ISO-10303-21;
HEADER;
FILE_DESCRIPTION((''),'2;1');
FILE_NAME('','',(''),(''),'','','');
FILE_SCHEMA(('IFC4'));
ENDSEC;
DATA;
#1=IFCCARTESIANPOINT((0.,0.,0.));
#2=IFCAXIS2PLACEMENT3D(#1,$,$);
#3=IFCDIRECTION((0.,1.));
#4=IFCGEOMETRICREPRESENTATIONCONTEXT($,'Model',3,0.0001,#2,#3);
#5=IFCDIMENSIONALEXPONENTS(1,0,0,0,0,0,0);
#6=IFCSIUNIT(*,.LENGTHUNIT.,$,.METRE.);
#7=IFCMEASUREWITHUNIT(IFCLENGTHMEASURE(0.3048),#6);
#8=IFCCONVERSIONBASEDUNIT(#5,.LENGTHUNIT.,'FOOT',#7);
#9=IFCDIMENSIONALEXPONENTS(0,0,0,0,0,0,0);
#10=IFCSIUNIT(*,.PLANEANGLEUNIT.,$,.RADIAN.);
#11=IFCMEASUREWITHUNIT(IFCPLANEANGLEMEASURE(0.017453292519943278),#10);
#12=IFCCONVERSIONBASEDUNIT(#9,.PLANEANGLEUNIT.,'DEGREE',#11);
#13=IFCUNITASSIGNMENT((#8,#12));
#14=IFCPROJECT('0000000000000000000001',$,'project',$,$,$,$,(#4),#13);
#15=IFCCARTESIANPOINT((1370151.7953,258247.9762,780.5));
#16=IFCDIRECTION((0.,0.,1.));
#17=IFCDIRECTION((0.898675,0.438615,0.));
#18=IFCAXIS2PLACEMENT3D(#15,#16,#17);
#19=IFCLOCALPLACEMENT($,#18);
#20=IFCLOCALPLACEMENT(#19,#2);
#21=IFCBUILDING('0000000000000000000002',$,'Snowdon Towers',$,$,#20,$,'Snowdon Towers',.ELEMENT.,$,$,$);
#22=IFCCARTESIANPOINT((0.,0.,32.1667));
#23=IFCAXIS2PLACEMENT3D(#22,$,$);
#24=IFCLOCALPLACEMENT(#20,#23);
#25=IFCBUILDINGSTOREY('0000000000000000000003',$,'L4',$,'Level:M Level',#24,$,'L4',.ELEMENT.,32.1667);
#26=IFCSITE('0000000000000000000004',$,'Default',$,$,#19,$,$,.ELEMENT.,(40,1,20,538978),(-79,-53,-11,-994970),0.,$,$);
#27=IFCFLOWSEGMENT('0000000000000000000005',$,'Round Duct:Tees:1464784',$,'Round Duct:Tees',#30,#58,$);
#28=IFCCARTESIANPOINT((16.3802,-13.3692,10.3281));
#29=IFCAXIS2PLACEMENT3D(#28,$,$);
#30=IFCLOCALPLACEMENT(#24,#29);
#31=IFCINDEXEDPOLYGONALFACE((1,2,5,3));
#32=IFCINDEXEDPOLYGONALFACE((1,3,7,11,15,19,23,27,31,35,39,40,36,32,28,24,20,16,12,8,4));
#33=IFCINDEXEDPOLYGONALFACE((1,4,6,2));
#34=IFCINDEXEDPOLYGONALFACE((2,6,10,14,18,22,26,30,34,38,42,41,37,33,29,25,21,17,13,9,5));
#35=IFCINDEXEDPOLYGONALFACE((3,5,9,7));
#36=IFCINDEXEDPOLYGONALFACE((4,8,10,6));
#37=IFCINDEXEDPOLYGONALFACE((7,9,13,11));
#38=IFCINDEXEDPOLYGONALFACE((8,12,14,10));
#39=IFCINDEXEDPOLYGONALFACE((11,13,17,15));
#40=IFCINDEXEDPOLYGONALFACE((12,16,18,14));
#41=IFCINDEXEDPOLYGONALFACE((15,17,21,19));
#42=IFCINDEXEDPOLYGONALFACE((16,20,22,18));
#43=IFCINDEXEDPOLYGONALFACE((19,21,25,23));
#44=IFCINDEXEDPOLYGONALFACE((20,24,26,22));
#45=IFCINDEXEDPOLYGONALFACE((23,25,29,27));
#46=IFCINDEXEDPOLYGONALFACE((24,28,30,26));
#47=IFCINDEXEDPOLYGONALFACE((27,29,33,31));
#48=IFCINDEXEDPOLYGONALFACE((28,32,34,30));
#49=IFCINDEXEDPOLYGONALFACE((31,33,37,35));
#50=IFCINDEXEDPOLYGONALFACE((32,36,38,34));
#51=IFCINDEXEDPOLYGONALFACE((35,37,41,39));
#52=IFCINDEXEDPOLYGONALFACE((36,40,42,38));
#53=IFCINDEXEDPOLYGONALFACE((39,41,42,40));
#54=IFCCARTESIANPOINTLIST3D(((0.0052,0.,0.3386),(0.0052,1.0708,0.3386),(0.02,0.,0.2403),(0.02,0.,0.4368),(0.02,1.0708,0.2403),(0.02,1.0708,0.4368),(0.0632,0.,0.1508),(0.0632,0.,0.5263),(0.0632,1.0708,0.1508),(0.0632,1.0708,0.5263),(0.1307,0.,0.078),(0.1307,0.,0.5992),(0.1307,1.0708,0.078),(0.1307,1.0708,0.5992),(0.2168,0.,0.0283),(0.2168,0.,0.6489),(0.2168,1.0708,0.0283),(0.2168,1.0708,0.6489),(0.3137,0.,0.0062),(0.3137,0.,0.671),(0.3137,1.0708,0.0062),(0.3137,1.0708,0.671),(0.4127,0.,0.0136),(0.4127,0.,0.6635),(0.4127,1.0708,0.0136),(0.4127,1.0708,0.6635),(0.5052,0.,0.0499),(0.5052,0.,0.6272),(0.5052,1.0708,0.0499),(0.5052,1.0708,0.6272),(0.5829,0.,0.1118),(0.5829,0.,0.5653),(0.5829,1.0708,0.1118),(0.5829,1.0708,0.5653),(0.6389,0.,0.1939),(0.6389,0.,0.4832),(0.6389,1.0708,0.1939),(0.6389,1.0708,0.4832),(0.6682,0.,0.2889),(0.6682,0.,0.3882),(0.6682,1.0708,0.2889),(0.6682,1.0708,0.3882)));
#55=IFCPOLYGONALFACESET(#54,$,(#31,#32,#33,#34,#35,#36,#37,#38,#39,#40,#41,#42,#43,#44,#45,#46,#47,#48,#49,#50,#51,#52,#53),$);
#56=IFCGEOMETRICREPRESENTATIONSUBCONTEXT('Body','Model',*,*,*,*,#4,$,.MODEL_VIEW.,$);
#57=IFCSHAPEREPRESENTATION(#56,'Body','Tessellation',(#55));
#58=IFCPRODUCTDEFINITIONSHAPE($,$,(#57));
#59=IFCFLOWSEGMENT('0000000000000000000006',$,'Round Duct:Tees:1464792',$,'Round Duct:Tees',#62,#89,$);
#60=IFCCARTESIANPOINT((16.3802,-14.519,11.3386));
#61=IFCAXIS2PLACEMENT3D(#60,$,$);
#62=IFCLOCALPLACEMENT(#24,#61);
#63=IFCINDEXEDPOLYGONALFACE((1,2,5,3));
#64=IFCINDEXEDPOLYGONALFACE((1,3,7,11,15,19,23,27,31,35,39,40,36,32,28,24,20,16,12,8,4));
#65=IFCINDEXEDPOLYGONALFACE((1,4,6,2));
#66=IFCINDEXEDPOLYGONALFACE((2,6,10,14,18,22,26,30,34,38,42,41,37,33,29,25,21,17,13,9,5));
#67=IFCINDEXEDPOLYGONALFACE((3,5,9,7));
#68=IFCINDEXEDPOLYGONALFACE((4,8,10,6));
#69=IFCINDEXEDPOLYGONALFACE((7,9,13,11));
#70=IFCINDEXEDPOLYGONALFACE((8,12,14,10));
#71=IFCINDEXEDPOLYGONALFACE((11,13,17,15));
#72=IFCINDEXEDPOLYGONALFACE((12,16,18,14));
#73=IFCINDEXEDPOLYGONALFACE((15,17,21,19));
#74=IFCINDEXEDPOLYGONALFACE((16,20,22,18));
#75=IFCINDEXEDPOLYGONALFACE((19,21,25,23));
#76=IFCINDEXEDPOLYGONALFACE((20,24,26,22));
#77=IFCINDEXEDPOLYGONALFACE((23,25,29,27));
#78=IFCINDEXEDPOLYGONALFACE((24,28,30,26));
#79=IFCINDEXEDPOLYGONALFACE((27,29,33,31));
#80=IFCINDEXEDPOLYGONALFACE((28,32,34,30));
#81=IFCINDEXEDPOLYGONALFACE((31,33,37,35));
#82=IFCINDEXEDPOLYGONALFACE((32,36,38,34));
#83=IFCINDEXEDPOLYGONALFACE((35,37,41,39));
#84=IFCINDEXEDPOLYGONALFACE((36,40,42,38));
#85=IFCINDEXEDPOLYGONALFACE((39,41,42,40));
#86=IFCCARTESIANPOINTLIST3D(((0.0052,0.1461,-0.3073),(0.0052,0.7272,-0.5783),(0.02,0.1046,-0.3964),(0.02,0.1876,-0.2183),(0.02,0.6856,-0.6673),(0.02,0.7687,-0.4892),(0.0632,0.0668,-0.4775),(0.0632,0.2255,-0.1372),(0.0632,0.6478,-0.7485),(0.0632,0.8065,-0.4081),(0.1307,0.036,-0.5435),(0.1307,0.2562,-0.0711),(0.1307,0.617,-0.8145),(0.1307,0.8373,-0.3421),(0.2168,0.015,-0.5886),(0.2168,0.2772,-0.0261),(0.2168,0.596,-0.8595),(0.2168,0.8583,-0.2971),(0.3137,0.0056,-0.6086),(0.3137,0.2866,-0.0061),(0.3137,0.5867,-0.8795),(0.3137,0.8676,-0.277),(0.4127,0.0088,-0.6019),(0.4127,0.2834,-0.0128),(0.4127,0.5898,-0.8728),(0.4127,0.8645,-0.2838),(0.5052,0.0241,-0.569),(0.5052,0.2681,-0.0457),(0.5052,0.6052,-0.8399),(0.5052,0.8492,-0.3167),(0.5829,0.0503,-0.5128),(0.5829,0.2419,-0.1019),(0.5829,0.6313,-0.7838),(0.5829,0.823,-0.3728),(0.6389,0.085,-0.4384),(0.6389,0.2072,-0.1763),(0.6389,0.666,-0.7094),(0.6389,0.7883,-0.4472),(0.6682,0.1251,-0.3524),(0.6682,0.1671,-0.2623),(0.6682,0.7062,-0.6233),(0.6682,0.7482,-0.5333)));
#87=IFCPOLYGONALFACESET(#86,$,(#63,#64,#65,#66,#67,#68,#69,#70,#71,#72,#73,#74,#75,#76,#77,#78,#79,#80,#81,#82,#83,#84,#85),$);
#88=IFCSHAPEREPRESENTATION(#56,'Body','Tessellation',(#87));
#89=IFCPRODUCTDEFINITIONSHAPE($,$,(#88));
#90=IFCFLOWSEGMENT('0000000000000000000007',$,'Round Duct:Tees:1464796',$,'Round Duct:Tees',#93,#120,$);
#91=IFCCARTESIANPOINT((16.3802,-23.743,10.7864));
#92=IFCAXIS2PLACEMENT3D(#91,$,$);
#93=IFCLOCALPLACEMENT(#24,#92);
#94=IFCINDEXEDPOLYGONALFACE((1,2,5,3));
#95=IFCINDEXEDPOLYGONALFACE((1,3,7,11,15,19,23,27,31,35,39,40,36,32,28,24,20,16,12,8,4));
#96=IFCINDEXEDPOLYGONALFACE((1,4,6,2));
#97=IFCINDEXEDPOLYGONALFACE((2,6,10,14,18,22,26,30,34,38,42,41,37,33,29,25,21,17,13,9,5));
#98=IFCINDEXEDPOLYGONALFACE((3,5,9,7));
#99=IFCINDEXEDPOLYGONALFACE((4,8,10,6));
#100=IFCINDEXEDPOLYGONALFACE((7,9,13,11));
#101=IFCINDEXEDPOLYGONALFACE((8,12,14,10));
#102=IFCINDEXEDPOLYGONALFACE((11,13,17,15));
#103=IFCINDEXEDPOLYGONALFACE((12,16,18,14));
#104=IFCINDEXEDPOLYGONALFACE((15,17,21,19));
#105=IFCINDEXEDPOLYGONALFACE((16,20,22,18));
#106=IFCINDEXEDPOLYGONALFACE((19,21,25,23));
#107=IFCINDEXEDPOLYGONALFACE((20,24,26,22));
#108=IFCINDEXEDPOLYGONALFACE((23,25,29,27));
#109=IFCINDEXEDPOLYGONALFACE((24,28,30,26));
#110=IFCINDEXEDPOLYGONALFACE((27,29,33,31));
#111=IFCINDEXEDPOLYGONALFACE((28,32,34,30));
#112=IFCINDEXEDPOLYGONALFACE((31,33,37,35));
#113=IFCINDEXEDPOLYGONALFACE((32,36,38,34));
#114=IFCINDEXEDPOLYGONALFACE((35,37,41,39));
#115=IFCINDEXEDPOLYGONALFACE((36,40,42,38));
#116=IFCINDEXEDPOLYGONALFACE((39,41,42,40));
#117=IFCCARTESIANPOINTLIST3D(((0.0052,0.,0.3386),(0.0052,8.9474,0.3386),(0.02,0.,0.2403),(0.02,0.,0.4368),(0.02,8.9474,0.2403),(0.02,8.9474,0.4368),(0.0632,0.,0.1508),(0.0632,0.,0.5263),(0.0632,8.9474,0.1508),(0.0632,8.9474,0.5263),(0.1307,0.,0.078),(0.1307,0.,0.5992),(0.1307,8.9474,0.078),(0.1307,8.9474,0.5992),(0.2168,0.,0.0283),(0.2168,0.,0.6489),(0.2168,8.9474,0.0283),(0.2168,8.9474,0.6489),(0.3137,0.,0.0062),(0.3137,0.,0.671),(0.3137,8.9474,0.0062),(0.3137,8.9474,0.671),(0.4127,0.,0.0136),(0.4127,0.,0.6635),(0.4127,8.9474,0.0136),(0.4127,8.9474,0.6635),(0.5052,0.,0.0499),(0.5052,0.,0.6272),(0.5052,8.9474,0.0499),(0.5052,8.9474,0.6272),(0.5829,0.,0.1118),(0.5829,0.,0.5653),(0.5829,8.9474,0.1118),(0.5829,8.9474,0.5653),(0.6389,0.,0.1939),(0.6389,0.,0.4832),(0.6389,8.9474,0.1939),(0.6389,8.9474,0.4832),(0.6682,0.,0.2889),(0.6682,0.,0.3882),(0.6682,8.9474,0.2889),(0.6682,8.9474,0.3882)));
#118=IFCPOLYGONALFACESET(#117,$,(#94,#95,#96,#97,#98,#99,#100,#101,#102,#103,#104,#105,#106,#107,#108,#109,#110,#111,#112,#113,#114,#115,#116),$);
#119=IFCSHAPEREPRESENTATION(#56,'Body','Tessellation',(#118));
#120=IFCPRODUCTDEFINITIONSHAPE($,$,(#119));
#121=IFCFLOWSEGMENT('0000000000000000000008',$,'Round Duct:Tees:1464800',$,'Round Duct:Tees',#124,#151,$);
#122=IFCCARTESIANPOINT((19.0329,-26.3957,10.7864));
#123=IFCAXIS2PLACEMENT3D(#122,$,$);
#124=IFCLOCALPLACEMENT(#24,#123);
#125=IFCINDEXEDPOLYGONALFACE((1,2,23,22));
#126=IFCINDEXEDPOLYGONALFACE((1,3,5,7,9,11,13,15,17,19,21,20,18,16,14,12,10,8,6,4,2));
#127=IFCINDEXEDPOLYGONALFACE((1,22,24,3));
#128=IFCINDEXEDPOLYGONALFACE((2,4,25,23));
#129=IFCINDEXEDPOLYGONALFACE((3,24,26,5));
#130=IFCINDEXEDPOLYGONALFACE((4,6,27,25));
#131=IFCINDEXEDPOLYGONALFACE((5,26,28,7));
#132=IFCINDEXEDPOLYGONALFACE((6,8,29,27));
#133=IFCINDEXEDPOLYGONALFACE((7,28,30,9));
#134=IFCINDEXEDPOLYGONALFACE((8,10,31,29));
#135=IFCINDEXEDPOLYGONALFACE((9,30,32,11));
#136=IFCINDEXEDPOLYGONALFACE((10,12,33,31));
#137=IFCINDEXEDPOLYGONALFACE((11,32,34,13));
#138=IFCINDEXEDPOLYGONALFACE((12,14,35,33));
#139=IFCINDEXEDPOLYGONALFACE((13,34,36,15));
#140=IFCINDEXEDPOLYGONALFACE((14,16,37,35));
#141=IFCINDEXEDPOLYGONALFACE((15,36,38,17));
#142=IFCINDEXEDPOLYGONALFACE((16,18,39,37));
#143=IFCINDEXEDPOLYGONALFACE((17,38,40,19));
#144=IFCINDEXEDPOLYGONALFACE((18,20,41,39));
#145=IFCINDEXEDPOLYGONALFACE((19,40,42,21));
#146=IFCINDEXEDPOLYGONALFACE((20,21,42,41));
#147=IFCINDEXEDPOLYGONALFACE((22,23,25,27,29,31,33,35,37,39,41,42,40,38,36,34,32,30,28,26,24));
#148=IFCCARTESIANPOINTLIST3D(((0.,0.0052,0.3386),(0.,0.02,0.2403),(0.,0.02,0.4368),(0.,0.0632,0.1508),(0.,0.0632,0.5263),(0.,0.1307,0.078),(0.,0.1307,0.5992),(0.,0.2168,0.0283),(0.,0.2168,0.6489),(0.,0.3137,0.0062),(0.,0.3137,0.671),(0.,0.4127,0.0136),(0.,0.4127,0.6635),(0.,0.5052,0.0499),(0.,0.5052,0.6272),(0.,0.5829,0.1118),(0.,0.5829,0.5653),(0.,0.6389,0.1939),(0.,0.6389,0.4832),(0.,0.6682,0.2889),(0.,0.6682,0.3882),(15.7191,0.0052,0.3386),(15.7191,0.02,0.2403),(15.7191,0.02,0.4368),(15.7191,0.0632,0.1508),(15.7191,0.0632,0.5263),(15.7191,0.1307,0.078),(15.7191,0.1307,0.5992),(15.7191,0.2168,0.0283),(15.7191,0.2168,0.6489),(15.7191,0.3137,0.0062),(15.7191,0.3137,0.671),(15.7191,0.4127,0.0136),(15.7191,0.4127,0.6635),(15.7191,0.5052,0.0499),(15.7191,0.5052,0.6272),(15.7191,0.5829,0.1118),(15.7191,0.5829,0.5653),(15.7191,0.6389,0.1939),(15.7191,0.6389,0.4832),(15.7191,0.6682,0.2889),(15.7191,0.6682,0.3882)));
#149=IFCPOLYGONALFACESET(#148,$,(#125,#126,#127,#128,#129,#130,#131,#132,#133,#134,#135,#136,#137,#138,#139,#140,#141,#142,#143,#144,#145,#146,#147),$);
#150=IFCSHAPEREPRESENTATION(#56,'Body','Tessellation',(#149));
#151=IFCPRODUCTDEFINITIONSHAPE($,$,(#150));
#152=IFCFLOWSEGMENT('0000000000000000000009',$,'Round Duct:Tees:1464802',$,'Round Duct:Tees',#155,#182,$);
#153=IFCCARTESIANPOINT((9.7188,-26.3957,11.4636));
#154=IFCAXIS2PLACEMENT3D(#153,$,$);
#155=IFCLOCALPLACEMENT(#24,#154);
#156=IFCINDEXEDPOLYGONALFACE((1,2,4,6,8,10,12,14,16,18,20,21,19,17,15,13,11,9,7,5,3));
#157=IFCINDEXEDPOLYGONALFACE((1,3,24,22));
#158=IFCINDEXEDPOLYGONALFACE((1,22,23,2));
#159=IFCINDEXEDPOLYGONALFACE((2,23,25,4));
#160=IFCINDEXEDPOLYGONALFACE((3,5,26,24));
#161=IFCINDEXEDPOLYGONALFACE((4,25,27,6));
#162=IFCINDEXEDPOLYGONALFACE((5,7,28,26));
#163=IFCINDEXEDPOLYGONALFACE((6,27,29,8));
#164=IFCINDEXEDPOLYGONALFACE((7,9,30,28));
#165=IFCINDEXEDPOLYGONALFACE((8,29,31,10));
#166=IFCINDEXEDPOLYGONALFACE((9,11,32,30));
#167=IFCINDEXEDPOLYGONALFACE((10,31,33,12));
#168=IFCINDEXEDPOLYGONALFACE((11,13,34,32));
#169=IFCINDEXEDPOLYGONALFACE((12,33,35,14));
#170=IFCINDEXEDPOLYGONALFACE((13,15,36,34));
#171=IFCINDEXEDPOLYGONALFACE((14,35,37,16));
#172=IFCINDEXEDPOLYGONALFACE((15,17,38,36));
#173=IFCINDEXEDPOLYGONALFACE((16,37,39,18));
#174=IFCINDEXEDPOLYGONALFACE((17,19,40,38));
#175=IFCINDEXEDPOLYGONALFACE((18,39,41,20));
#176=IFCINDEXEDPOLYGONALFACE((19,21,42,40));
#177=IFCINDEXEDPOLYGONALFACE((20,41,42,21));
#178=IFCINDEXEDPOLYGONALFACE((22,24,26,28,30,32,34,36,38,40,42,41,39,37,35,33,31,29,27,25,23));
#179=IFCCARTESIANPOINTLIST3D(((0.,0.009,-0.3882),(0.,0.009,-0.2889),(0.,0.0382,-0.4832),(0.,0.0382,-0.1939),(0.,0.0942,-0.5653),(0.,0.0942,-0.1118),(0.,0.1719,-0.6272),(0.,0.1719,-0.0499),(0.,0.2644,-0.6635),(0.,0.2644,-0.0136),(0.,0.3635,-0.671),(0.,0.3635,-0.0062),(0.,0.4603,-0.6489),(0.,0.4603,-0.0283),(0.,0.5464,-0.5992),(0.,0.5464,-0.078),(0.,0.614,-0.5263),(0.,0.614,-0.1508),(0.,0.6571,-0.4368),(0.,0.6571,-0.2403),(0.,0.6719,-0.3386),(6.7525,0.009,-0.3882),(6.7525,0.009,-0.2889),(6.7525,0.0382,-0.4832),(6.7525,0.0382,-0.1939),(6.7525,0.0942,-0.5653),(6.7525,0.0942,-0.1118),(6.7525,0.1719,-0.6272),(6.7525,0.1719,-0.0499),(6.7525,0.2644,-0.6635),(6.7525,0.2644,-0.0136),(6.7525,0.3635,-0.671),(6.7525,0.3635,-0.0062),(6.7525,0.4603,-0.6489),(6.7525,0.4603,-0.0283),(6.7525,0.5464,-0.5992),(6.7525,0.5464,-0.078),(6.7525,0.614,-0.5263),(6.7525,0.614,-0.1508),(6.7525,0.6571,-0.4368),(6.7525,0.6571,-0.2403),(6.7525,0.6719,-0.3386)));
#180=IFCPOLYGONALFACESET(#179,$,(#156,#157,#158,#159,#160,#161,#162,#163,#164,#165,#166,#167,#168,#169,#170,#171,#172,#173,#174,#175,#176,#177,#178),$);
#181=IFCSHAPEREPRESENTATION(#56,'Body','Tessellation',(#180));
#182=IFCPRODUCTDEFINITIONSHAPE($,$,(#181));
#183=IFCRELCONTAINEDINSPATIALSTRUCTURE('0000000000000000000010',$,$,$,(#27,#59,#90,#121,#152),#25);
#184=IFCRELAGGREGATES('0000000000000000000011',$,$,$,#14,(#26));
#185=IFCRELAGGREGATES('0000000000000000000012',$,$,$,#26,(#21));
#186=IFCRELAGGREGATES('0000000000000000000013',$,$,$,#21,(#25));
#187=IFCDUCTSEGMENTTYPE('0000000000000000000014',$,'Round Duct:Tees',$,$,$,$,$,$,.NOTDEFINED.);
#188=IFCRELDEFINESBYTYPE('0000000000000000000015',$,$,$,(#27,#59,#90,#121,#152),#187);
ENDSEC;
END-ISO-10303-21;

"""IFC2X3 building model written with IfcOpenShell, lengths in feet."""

from ifc_helpers import new_model, entity, si_unit, converted_unit, direction, frame, frame_2d, origin, origin_2d_with_axis, place, context, subcontext, project, spatial, circle, extrude, type_object, element, save


model = new_model("IFC2X3")

# Units and contexts
model_context = context("Model", 3, precision=0.0001, world=origin(), true_north=direction((0.0, 1.0)))
body_context = subcontext(model_context, "Body", "Model", "MODEL_VIEW")
ifc_project = project(units=[converted_unit("LENGTHUNIT", "FOOT", entity("IfcLengthMeasure", 0.3048), si_unit("LENGTHUNIT", "METRE"), dimensions=[1, 0, 0, 0, 0, 0, 0]), converted_unit("PLANEANGLEUNIT", "DEGREE", entity("IfcPlaneAngleMeasure", 0.017453292519943278), si_unit("PLANEANGLEUNIT", "RADIAN"), dimensions=[0, 0, 0, 0, 0, 0, 0])], contexts=[model_context])

# Site, building, storey
site_placement = place(None, frame((1370151.7953, 258247.9762, 780.5), z_axis=(0.0, 0.0, 1.0), x_axis=(0.898675, 0.438615, 0.0)))
site = spatial("IfcSite", under=ifc_project, at=site_placement, Name="Default", CompositionType="ELEMENT", RefLatitude=(40, 1, 20, 538978), RefLongitude=(-79, -53, -11, -994970), RefElevation=0.0)
building_placement = place(site_placement, origin())
building = spatial("IfcBuilding", under=site, at=building_placement, Name="Snowdon Towers", LongName="Snowdon Towers", CompositionType="ELEMENT")
storey_placement = place(building_placement, frame((0.0, 0.0, 32.1667)))
storey = spatial("IfcBuildingStorey", under=building, at=storey_placement, Name="L4", ObjectType="Level:M Level", LongName="L4", CompositionType="ELEMENT", Elevation=32.1667)

# Flow segments
duct_segment_type = type_object("IfcDuctSegmentType", Name="Round Duct:Tees", PredefinedType="NOTDEFINED")
flow_segment_1_placement = place(storey_placement, frame((16.3802, -13.3692, 10.3281)))
element("IfcFlowSegment", 1, at=flow_segment_1_placement, inside=storey, type_object=duct_segment_type, Name="Round Duct:Tees:1464784", ObjectType="Round Duct:Tees", context=body_context, shape_type="SweptSolid", body=[
    extrude(circle(Radius=0.3333, at=origin_2d_with_axis()), frame((0.3386, 0.0, 0.3386), z_axis=(0.0, 1.0, 0.0), x_axis=(-1.0, 0.0, 0.0)), (0.0, 0.0, 1.0), 1.0708),
])
flow_segment_2_placement = place(storey_placement, frame((16.3802, -14.519, 11.3386)))
element("IfcFlowSegment", 2, at=flow_segment_2_placement, inside=storey, type_object=duct_segment_type, Name="Round Duct:Tees:1464792", ObjectType="Round Duct:Tees", context=body_context, shape_type="SweptSolid", body=[
    extrude(circle(Radius=0.3333, at=frame_2d((0.0, 0.0), x_axis=(1.0, 0.0))), frame((0.3386, 0.7272, -0.5783), z_axis=(0.0, -0.906308, 0.422618), x_axis=(-1.0, 0.0, 0.0)), (0.0, 0.0, 1.0), 0.6411),
])
flow_segment_3_placement = place(storey_placement, frame((16.3802, -23.743, 10.7864)))
element("IfcFlowSegment", 3, at=flow_segment_3_placement, inside=storey, type_object=duct_segment_type, Name="Round Duct:Tees:1464796", ObjectType="Round Duct:Tees", context=body_context, shape_type="SweptSolid", body=[
    extrude(circle(Radius=0.3333, at=frame_2d((0.0, 0.0), x_axis=(1.0, 0.0))), frame((0.3386, 0.0, 0.3386), z_axis=(0.0, 1.0, 0.0), x_axis=(-1.0, 0.0, 0.0)), (0.0, 0.0, 1.0), 8.9474),
])
flow_segment_4_placement = place(storey_placement, frame((19.0329, -26.3957, 10.7864)))
element("IfcFlowSegment", 4, at=flow_segment_4_placement, inside=storey, type_object=duct_segment_type, Name="Round Duct:Tees:1464800", ObjectType="Round Duct:Tees", context=body_context, shape_type="SweptSolid", body=[
    extrude(circle(Radius=0.3333, at=frame_2d((0.0, 0.0), x_axis=(1.0, 0.0))), frame((0.0, 0.3386, 0.3386), z_axis=(1.0, 0.0, 0.0), x_axis=(0.0, -1.0, 0.0)), (0.0, 0.0, 1.0), 15.7191),
])
flow_segment_5_placement = place(storey_placement, frame((9.7188, -26.3957, 11.4636)))
element("IfcFlowSegment", 5, at=flow_segment_5_placement, inside=storey, type_object=duct_segment_type, Name="Round Duct:Tees:1464802", ObjectType="Round Duct:Tees", context=body_context, shape_type="SweptSolid", body=[
    extrude(circle(Radius=0.3333, at=frame_2d((0.0, 0.0), x_axis=(1.0, 0.0))), frame((0.0, 0.3386, -0.3386), z_axis=(1.0, 0.0, 0.0), x_axis=(0.0, 1.0, 0.0)), (0.0, 0.0, 1.0), 6.7525),
])

save(model, "model.ifc")
